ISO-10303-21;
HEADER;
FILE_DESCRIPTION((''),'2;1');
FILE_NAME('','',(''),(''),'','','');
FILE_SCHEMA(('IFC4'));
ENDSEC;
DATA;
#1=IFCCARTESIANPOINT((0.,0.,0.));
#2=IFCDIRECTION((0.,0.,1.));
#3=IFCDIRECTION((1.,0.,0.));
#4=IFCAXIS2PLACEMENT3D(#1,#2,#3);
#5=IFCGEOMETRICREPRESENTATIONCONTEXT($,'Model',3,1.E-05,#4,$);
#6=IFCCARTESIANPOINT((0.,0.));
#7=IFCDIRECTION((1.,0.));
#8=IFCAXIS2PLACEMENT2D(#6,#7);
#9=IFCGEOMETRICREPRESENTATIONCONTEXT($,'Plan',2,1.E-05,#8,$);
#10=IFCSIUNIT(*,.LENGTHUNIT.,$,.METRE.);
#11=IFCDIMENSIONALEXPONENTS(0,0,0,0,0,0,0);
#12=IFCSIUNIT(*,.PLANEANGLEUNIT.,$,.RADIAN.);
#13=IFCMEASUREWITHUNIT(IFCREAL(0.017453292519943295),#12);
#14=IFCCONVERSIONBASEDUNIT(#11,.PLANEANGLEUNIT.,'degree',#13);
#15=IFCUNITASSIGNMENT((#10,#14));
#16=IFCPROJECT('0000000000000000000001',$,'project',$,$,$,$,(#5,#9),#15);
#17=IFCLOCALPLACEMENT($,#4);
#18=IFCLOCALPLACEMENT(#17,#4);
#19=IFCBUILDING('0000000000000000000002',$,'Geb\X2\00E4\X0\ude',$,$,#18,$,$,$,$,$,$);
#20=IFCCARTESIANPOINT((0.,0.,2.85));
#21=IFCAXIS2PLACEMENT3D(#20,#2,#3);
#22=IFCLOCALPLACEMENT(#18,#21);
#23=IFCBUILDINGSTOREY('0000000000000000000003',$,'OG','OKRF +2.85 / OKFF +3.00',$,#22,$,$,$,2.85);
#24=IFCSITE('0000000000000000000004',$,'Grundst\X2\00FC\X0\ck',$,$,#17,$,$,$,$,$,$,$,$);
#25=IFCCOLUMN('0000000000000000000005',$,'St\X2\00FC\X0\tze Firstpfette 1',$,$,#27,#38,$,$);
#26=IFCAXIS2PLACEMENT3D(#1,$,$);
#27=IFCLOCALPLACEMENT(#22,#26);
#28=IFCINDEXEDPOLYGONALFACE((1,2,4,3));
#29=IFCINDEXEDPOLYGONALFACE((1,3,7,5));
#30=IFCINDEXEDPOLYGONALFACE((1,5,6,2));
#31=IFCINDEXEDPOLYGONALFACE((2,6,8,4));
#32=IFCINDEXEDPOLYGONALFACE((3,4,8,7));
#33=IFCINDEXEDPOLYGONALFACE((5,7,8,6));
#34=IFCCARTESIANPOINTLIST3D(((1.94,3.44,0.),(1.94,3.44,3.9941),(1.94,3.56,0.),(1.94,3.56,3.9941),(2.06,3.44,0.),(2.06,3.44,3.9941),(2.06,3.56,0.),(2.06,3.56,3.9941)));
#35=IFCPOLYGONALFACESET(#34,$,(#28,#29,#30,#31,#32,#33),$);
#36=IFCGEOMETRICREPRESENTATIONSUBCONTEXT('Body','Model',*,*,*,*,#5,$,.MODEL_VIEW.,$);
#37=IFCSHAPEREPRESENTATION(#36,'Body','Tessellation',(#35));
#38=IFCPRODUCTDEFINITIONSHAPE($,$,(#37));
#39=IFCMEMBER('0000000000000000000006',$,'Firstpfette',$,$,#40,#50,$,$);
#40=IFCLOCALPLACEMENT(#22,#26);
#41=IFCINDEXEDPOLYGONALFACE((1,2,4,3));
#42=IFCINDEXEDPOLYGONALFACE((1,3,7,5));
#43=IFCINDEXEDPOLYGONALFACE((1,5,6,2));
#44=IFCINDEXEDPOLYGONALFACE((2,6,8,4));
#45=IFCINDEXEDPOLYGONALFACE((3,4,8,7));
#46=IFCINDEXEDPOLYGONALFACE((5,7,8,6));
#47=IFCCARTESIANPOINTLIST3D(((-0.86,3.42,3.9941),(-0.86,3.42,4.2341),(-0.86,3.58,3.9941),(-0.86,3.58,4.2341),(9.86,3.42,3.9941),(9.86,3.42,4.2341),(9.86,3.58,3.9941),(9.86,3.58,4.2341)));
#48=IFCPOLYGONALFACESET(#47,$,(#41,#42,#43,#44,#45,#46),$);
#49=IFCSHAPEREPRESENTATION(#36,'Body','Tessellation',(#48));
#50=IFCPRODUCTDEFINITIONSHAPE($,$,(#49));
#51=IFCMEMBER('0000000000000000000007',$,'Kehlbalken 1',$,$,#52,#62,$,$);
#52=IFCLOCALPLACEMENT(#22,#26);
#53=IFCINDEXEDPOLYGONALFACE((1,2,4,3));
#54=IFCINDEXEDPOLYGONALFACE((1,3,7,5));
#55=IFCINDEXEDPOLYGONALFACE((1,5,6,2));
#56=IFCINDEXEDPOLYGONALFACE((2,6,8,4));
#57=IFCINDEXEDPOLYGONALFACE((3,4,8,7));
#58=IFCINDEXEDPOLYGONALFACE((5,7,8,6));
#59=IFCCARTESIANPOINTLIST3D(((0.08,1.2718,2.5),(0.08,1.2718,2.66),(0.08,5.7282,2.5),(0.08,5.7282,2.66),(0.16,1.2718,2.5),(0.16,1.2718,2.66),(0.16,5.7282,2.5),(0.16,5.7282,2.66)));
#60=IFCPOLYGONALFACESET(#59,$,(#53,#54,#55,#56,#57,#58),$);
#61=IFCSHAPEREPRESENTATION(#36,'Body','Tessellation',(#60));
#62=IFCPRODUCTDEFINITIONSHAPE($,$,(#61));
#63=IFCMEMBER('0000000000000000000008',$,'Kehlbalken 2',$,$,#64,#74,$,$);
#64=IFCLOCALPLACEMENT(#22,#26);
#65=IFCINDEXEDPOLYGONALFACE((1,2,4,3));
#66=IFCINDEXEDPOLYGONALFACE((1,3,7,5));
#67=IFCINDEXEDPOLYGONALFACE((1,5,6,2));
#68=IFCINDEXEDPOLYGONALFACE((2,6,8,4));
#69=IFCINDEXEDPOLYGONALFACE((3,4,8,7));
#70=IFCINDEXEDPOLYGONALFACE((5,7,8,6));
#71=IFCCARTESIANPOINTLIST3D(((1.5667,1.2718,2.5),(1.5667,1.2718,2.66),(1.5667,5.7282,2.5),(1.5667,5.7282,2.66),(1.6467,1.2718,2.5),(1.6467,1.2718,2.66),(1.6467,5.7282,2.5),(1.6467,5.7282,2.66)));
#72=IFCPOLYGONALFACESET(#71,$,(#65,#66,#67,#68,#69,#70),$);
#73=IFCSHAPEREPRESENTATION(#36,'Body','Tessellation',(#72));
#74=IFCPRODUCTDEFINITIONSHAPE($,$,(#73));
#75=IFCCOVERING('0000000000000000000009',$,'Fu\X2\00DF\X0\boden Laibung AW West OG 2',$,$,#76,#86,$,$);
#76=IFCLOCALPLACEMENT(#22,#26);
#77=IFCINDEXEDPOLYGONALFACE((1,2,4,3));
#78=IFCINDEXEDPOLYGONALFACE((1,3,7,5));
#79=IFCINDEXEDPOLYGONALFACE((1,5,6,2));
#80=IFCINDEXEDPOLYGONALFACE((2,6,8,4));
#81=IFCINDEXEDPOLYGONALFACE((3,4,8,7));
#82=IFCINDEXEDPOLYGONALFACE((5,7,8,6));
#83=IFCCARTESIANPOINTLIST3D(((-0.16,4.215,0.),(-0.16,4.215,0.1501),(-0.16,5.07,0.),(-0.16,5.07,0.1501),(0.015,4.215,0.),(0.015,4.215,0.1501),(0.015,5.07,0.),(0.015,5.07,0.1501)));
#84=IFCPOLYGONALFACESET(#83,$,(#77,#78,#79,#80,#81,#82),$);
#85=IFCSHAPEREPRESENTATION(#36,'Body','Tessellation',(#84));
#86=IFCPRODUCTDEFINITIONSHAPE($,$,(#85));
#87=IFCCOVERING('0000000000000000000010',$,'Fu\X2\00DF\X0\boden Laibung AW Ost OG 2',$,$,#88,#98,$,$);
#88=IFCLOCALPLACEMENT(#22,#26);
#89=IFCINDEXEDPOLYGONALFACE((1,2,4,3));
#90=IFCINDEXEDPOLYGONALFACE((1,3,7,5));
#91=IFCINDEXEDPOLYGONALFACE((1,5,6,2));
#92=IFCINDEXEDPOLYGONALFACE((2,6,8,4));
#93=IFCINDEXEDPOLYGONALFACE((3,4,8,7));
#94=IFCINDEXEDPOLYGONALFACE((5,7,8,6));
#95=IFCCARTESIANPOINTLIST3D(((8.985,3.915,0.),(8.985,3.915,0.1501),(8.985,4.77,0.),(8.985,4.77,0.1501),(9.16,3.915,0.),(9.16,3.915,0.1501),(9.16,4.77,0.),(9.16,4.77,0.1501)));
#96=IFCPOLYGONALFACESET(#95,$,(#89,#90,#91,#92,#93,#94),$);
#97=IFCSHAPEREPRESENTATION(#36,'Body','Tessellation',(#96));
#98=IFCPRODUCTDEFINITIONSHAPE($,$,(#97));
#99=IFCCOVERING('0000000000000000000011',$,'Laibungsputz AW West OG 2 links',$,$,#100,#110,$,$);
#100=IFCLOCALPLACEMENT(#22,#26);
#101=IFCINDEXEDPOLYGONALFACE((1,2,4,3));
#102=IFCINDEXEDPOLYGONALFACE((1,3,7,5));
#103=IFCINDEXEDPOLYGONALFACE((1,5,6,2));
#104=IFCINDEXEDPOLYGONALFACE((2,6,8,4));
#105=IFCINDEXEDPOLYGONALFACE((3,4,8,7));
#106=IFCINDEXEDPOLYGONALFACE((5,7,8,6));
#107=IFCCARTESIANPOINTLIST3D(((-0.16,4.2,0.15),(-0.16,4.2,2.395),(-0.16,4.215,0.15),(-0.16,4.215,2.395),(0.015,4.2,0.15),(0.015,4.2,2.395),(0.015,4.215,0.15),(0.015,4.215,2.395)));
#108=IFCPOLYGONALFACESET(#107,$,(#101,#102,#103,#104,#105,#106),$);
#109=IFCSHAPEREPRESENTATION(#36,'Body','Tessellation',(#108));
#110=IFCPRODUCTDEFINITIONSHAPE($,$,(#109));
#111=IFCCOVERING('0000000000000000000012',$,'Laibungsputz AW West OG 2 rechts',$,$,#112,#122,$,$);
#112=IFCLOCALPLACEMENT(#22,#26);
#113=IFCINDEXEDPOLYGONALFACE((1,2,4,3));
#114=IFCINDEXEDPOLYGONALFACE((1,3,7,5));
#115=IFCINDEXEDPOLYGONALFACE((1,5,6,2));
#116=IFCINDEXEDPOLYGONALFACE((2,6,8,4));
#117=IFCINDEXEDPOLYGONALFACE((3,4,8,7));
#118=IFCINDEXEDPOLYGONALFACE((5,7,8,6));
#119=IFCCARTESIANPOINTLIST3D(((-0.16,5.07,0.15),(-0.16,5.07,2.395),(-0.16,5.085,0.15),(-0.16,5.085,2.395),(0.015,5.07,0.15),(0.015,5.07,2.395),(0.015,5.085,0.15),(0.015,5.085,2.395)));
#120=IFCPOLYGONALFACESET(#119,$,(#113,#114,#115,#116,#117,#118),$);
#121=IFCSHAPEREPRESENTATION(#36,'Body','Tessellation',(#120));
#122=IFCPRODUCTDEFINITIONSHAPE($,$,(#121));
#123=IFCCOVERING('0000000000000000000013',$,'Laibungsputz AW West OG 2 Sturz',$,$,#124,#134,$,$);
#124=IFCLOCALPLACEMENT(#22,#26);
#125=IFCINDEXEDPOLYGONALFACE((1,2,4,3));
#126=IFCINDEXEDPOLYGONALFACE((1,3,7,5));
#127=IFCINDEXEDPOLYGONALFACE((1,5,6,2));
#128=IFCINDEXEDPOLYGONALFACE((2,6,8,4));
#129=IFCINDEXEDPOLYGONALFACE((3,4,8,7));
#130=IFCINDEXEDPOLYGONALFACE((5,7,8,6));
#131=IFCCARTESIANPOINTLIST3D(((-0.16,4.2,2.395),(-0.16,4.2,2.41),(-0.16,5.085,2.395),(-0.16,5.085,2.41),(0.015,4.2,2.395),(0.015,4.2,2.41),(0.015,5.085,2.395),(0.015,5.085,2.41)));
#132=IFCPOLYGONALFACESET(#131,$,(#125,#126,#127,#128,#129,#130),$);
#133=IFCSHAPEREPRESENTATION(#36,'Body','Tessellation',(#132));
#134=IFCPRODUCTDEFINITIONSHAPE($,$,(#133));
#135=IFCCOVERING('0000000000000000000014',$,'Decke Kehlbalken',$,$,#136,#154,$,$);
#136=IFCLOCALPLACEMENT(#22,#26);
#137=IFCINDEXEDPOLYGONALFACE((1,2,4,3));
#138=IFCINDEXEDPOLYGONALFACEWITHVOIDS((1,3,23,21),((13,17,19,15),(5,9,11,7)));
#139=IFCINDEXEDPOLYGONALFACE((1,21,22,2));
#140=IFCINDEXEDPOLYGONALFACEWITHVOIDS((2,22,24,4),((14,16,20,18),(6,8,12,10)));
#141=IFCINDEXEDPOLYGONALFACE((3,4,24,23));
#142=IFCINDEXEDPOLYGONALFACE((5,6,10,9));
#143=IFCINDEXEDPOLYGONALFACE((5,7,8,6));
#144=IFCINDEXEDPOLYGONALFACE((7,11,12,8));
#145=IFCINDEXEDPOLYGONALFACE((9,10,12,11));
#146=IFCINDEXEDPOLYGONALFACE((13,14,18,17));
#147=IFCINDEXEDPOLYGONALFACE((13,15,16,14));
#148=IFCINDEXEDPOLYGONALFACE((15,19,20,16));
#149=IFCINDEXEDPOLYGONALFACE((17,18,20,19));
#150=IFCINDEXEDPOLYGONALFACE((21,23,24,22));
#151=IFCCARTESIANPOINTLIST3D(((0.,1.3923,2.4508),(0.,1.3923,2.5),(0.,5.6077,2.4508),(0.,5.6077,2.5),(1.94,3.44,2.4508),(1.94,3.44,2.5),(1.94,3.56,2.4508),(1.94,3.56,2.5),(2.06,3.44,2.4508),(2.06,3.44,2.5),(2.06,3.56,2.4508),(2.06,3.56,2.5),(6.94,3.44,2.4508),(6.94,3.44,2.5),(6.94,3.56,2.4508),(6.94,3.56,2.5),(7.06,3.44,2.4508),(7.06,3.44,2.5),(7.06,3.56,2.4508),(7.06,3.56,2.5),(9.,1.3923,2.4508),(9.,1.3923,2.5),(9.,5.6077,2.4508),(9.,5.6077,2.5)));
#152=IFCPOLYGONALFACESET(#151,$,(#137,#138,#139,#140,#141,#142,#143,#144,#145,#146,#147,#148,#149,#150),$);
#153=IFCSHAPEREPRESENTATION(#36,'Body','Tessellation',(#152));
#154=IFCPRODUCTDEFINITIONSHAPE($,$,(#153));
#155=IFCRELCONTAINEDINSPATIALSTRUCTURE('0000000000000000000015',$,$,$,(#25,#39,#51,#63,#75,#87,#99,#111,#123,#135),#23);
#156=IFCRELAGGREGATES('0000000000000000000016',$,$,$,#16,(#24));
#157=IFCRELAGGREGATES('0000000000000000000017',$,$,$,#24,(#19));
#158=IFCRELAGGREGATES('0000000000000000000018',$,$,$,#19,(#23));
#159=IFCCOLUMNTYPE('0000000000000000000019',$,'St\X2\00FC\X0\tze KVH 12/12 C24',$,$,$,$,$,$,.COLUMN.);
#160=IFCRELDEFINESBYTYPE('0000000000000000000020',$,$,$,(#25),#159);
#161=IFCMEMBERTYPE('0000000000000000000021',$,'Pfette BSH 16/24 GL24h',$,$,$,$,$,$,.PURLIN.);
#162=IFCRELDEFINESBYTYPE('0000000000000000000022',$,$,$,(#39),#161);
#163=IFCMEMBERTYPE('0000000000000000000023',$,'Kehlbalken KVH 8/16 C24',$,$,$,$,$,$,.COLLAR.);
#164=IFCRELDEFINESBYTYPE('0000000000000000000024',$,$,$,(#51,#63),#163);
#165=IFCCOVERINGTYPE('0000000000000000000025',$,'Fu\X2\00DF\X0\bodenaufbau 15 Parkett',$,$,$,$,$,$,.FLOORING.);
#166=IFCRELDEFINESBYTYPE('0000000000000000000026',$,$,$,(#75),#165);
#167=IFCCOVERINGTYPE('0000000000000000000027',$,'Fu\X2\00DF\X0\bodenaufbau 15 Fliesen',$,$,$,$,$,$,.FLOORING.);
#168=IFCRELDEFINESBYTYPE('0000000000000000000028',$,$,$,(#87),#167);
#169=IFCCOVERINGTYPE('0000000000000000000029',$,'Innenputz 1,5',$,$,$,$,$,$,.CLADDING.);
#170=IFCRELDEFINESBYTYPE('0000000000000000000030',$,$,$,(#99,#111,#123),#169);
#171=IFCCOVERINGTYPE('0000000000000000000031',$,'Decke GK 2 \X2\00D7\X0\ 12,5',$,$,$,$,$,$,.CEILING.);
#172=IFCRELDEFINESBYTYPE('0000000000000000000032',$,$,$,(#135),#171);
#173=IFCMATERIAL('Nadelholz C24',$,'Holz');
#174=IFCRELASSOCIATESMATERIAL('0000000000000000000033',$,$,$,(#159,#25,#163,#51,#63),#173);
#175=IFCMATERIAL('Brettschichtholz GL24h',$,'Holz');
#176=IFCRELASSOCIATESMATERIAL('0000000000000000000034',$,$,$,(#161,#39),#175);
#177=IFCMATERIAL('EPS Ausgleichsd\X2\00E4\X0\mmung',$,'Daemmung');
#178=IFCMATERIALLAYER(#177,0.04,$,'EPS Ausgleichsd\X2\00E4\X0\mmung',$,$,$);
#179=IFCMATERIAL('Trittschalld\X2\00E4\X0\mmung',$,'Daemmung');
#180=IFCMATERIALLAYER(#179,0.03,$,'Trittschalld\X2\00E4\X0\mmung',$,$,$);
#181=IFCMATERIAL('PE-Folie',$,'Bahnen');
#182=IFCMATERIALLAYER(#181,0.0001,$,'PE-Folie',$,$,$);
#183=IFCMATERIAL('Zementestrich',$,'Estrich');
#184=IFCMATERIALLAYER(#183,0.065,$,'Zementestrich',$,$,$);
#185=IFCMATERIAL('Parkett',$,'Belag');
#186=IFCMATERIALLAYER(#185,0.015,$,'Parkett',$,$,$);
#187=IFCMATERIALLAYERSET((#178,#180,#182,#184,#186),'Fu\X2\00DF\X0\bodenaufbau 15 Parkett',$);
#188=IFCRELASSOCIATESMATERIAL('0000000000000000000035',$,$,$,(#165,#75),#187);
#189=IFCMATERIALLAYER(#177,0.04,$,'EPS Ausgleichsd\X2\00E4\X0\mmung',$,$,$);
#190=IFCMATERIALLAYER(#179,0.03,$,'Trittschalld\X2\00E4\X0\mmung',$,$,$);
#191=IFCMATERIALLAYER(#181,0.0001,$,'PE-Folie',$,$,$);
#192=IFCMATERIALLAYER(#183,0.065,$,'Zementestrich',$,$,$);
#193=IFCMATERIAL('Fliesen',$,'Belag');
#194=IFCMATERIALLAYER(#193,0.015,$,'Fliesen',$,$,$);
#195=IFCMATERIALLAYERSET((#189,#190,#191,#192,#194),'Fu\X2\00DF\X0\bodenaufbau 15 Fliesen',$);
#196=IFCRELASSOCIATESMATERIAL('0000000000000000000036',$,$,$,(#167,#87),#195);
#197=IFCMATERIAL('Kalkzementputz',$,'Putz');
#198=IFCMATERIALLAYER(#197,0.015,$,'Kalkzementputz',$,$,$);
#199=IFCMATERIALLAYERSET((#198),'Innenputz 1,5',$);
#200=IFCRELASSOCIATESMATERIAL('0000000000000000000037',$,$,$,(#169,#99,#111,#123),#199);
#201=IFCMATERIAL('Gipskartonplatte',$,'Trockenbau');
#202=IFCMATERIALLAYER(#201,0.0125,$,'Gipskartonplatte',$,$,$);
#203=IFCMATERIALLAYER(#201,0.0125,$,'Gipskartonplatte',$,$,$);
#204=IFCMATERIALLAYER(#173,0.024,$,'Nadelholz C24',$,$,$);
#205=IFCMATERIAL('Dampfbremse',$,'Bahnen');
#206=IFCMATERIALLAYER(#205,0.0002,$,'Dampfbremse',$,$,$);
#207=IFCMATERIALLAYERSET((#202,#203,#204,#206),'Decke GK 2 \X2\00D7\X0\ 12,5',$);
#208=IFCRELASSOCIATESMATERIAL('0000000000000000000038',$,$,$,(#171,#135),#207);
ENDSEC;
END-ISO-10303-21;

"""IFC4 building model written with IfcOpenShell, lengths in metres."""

from ifc_helpers import new_model, entity, si_unit, converted_unit, frame, origin_with_axes, origin_2d_with_axis, place, context, subcontext, project, spatial, polyline, indexed_curve, rectangle, outline, extrude, material, layer, layer_set, layer_usage, material_profile, profile_set, profile_usage, type_object, element, save


model = new_model("IFC4")

# Units and contexts
model_context = context("Model", 3, precision=1e-05, world=origin_with_axes())
plan_context = context("Plan", 2, precision=1e-05, world=origin_2d_with_axis())
body_context = subcontext(model_context, "Body", "Model", "MODEL_VIEW")
ifc_project = project(units=[si_unit("LENGTHUNIT", "METRE"), converted_unit("PLANEANGLEUNIT", "degree", entity("IfcReal", 0.017453292519943295), si_unit("PLANEANGLEUNIT", "RADIAN"), dimensions=[0, 0, 0, 0, 0, 0, 0])], contexts=[model_context, plan_context])

# Site, building, storey
site_placement = place(None, origin_with_axes())
site = spatial("IfcSite", under=ifc_project, at=site_placement, Name="Grundstück")
building_placement = place(site_placement, origin_with_axes())
building = spatial("IfcBuilding", under=site, at=building_placement, Name="Gebäude")
storey_placement = place(building_placement, frame((0.0, 0.0, 2.85), z_axis=(0.0, 0.0, 1.0), x_axis=(1.0, 0.0, 0.0)))
storey = spatial("IfcBuildingStorey", under=building, at=storey_placement, Name="OG", Description="OKRF +2.85 / OKFF +3.00", Elevation=2.85)

# Column
ifc_material_1 = material(Name="Nadelholz C24", Category="Holz")
ifc_material_profile_1 = material_profile(ifc_material_1, rectangle(XDim=0.12, YDim=0.12))
ifc_profile_set_1 = profile_set([ifc_material_profile_1], Name="Stütze KVH 12/12 C24")
ifc_profile_usage_1 = profile_usage(ifc_profile_set_1)
column_type = type_object("IfcColumnType", Name="Stütze KVH 12/12 C24", PredefinedType="COLUMN", material=ifc_profile_set_1)
column_placement = place(storey_placement, frame((2.0, 3.5, 0.0), z_axis=(0.0, 0.0, 1.0), x_axis=(1.0, 0.0, 0.0)))
element("IfcColumn", 1, at=column_placement, inside=storey, type_object=column_type, material=ifc_profile_usage_1, Name="Stütze Firstpfette 1", context=body_context, shape_type="SweptSolid", body=[
    extrude(rectangle(XDim=0.12, YDim=0.12), origin_with_axes(), (0.0, 0.0, 1.0), 3.9941),
])

# Members
ifc_material_2 = material(Name="Brettschichtholz GL24h", Category="Holz")
ifc_material_profile_2 = material_profile(ifc_material_2, rectangle(XDim=0.16, YDim=0.24))
ifc_profile_set_2 = profile_set([ifc_material_profile_2], Name="Pfette BSH 16/24 GL24h")
ifc_profile_usage_2 = profile_usage(ifc_profile_set_2)
member_type_1 = type_object("IfcMemberType", Name="Pfette BSH 16/24 GL24h", PredefinedType="PURLIN", material=ifc_profile_set_2)
member_1_placement = place(storey_placement, frame((-0.86, 3.5, 4.1141), z_axis=(1.0, 0.0, 0.0), x_axis=(0.0, 1.0, 0.0)))
element("IfcMember", 2, at=member_1_placement, inside=storey, type_object=member_type_1, material=ifc_profile_usage_2, Name="Firstpfette", context=body_context, shape_type="SweptSolid", body=[
    extrude(rectangle(XDim=0.16, YDim=0.24), origin_with_axes(), (0.0, 0.0, 1.0), 10.72),
])
ifc_material_profile_3 = material_profile(ifc_material_1, rectangle(XDim=0.08, YDim=0.16))
ifc_profile_set_3 = profile_set([ifc_material_profile_3], Name="Kehlbalken KVH 8/16 C24")
ifc_profile_usage_3 = profile_usage(ifc_profile_set_3)
member_type_2 = type_object("IfcMemberType", Name="Kehlbalken KVH 8/16 C24", PredefinedType="COLLAR", material=ifc_profile_set_3)
member_2_placement = place(storey_placement, frame((0.12, 1.2718, 2.58), z_axis=(0.0, 1.0, 0.0), x_axis=(-1.0, 0.0, 0.0)))
element("IfcMember", 3, at=member_2_placement, inside=storey, type_object=member_type_2, material=ifc_profile_usage_3, Name="Kehlbalken 1", context=body_context, shape_type="SweptSolid", body=[
    extrude(rectangle(XDim=0.08, YDim=0.16), origin_with_axes(), (0.0, 0.0, 1.0), 4.4564),
])
ifc_profile_usage_4 = profile_usage(ifc_profile_set_3)
member_3_placement = place(storey_placement, frame((1.6067, 1.2718, 2.58), z_axis=(0.0, 1.0, 0.0), x_axis=(-1.0, 0.0, 0.0)))
element("IfcMember", 4, at=member_3_placement, inside=storey, type_object=member_type_2, material=ifc_profile_usage_4, Name="Kehlbalken 2", context=body_context, shape_type="SweptSolid", body=[
    extrude(rectangle(XDim=0.08, YDim=0.16), origin_with_axes(), (0.0, 0.0, 1.0), 4.4564),
])

# Coverings
ifc_material_3 = material(Name="EPS Ausgleichsdämmung", Category="Daemmung")
ifc_layer_1 = layer(ifc_material_3, 0.04, Name="EPS Ausgleichsdämmung")
ifc_material_4 = material(Name="Trittschalldämmung", Category="Daemmung")
ifc_layer_2 = layer(ifc_material_4, 0.03, Name="Trittschalldämmung")
ifc_material_5 = material(Name="PE-Folie", Category="Bahnen")
ifc_layer_3 = layer(ifc_material_5, 0.0001, Name="PE-Folie")
ifc_material_6 = material(Name="Zementestrich", Category="Estrich")
ifc_layer_4 = layer(ifc_material_6, 0.065, Name="Zementestrich")
ifc_material_7 = material(Name="Parkett", Category="Belag")
ifc_layer_5 = layer(ifc_material_7, 0.015, Name="Parkett")
ifc_layer_set_1 = layer_set([ifc_layer_1, ifc_layer_2, ifc_layer_3, ifc_layer_4, ifc_layer_5], Name="Fußbodenaufbau 15 Parkett")
ifc_layer_usage_1 = layer_usage(ifc_layer_set_1, "AXIS3", "POSITIVE", 0.0)
covering_type_1 = type_object("IfcCoveringType", Name="Fußbodenaufbau 15 Parkett", PredefinedType="FLOORING", material=ifc_layer_set_1)
covering_1_placement = place(storey_placement, origin_with_axes())
element("IfcCovering", 5, at=covering_1_placement, inside=storey, type_object=covering_type_1, material=ifc_layer_usage_1, Name="Fußboden Laibung AW West OG 2", context=body_context, shape_type="SweptSolid", body=[
    extrude(outline(indexed_curve([(-0.16, 4.215), (0.015, 4.215), (0.015, 5.07), (-0.16, 5.07)])), None, (0.0, 0.0, 1.0), 0.1501),
])
ifc_layer_6 = layer(ifc_material_3, 0.04, Name="EPS Ausgleichsdämmung")
ifc_layer_7 = layer(ifc_material_4, 0.03, Name="Trittschalldämmung")
ifc_layer_8 = layer(ifc_material_5, 0.0001, Name="PE-Folie")
ifc_layer_9 = layer(ifc_material_6, 0.065, Name="Zementestrich")
ifc_material_8 = material(Name="Fliesen", Category="Belag")
ifc_layer_10 = layer(ifc_material_8, 0.015, Name="Fliesen")
ifc_layer_set_2 = layer_set([ifc_layer_6, ifc_layer_7, ifc_layer_8, ifc_layer_9, ifc_layer_10], Name="Fußbodenaufbau 15 Fliesen")
ifc_layer_usage_2 = layer_usage(ifc_layer_set_2, "AXIS3", "POSITIVE", 0.0)
covering_type_2 = type_object("IfcCoveringType", Name="Fußbodenaufbau 15 Fliesen", PredefinedType="FLOORING", material=ifc_layer_set_2)
covering_2_placement = place(storey_placement, origin_with_axes())
element("IfcCovering", 6, at=covering_2_placement, inside=storey, type_object=covering_type_2, material=ifc_layer_usage_2, Name="Fußboden Laibung AW Ost OG 2", context=body_context, shape_type="SweptSolid", body=[
    extrude(outline(indexed_curve([(8.985, 3.915), (9.16, 3.915), (9.16, 4.77), (8.985, 4.77)])), None, (0.0, 0.0, 1.0), 0.1501),
])
ifc_material_9 = material(Name="Kalkzementputz", Category="Putz")
ifc_layer_11 = layer(ifc_material_9, 0.015, Name="Kalkzementputz")
ifc_layer_set_3 = layer_set([ifc_layer_11], Name="Innenputz 1,5")
ifc_layer_usage_3 = layer_usage(ifc_layer_set_3, "AXIS1", "POSITIVE", 4.2)
covering_type_3 = type_object("IfcCoveringType", Name="Innenputz 1,5", PredefinedType="CLADDING", material=ifc_layer_set_3)
covering_3_placement = place(storey_placement, frame((0.0, 0.0, 0.0), z_axis=(0.0, 0.0, 1.0), x_axis=(0.0, 1.0, 0.0)))
element("IfcCovering", 7, at=covering_3_placement, inside=storey, type_object=covering_type_3, material=ifc_layer_usage_3, Name="Laibungsputz AW West OG 2 links", context=body_context, shape_type="SweptSolid", body=[
    extrude(outline(polyline([(-0.015, 0.15), (0.16, 0.15), (0.16, 2.395), (-0.015, 2.395), (-0.015, 0.15)])), frame((4.2, 0.0, 0.0), z_axis=(1.0, 0.0, 0.0), x_axis=(0.0, 1.0, 0.0)), (0.0, 0.0, 1.0), 0.015),
])
ifc_layer_usage_4 = layer_usage(ifc_layer_set_3, "AXIS1", "POSITIVE", 5.07)
covering_4_placement = place(storey_placement, frame((0.0, 0.0, 0.0), z_axis=(0.0, 0.0, 1.0), x_axis=(0.0, 1.0, 0.0)))
element("IfcCovering", 8, at=covering_4_placement, inside=storey, type_object=covering_type_3, material=ifc_layer_usage_4, Name="Laibungsputz AW West OG 2 rechts", context=body_context, shape_type="SweptSolid", body=[
    extrude(outline(polyline([(-0.015, 0.15), (0.16, 0.15), (0.16, 2.395), (-0.015, 2.395), (-0.015, 0.15)])), frame((5.07, 0.0, 0.0), z_axis=(1.0, 0.0, 0.0), x_axis=(0.0, 1.0, 0.0)), (0.0, 0.0, 1.0), 0.015),
])
ifc_layer_usage_5 = layer_usage(ifc_layer_set_3, "AXIS3", "POSITIVE", 2.395)
covering_5_placement = place(storey_placement, frame((0.0, 0.0, 0.0), z_axis=(0.0, 0.0, 1.0), x_axis=(0.0, 1.0, 0.0)))
element("IfcCovering", 9, at=covering_5_placement, inside=storey, type_object=covering_type_3, material=ifc_layer_usage_5, Name="Laibungsputz AW West OG 2 Sturz", context=body_context, shape_type="SweptSolid", body=[
    extrude(outline(polyline([(-0.015, 2.395), (0.16, 2.395), (0.16, 2.41), (-0.015, 2.41), (-0.015, 2.395)])), frame((4.2, 0.0, 0.0), z_axis=(1.0, 0.0, 0.0), x_axis=(0.0, 1.0, 0.0)), (0.0, 0.0, 1.0), 0.885),
])

# Covering, openings
ifc_material_10 = material(Name="Gipskartonplatte", Category="Trockenbau")
ifc_layer_12 = layer(ifc_material_10, 0.0125, Name="Gipskartonplatte")
ifc_layer_13 = layer(ifc_material_10, 0.0125, Name="Gipskartonplatte")
ifc_layer_14 = layer(ifc_material_1, 0.024, Name="Nadelholz C24")
ifc_material_11 = material(Name="Dampfbremse", Category="Bahnen")
ifc_layer_15 = layer(ifc_material_11, 0.0002, Name="Dampfbremse")
ifc_layer_set_4 = layer_set([ifc_layer_12, ifc_layer_13, ifc_layer_14, ifc_layer_15], Name="Decke GK 2 × 12,5")
ifc_layer_usage_6 = layer_usage(ifc_layer_set_4, "AXIS3", "POSITIVE", 0.0)
covering_type_4 = type_object("IfcCoveringType", Name="Decke GK 2 × 12,5", PredefinedType="CEILING", material=ifc_layer_set_4)
covering_6_placement = place(storey_placement, frame((0.0, 0.0, 2.4508), z_axis=(0.0, 0.0, 1.0), x_axis=(1.0, 0.0, 0.0)))
covering_6 = element("IfcCovering", 10, at=covering_6_placement, inside=storey, type_object=covering_type_4, material=ifc_layer_usage_6, Name="Decke Kehlbalken", context=body_context, shape_type="SweptSolid", body=[
    extrude(outline(indexed_curve([(0.0, 1.3923), (9.0, 1.3923), (9.0, 5.6077), (0.0, 5.6077)])), None, (0.0, 0.0, 1.0), 0.0492),
])
opening_1_placement = place(covering_6_placement, frame((1.94, 3.44, -0.05), z_axis=(0.0, 0.0, 1.0), x_axis=(1.0, 0.0, 0.0)))
element("IfcOpeningElement", 11, at=opening_1_placement, cuts=covering_6, context=body_context, shape_type="SweptSolid", body=[
    extrude(outline(indexed_curve([(0.0, 0.0), (0.0, 0.12), (0.12, 0.12), (0.12, 0.0), (0.0, 0.0)], self_intersect=False)), origin_with_axes(), (0.0, 0.0, 1.0), 0.1492),
])
opening_2_placement = place(covering_6_placement, frame((6.94, 3.44, -0.05), z_axis=(0.0, 0.0, 1.0), x_axis=(1.0, 0.0, 0.0)))
element("IfcOpeningElement", 12, at=opening_2_placement, cuts=covering_6, context=body_context, shape_type="SweptSolid", body=[
    extrude(outline(indexed_curve([(0.0, 0.0), (0.0, 0.12), (0.12, 0.12), (0.12, 0.0), (0.0, 0.0)], self_intersect=False)), origin_with_axes(), (0.0, 0.0, 1.0), 0.1492),
])

save(model, "model.ifc")
